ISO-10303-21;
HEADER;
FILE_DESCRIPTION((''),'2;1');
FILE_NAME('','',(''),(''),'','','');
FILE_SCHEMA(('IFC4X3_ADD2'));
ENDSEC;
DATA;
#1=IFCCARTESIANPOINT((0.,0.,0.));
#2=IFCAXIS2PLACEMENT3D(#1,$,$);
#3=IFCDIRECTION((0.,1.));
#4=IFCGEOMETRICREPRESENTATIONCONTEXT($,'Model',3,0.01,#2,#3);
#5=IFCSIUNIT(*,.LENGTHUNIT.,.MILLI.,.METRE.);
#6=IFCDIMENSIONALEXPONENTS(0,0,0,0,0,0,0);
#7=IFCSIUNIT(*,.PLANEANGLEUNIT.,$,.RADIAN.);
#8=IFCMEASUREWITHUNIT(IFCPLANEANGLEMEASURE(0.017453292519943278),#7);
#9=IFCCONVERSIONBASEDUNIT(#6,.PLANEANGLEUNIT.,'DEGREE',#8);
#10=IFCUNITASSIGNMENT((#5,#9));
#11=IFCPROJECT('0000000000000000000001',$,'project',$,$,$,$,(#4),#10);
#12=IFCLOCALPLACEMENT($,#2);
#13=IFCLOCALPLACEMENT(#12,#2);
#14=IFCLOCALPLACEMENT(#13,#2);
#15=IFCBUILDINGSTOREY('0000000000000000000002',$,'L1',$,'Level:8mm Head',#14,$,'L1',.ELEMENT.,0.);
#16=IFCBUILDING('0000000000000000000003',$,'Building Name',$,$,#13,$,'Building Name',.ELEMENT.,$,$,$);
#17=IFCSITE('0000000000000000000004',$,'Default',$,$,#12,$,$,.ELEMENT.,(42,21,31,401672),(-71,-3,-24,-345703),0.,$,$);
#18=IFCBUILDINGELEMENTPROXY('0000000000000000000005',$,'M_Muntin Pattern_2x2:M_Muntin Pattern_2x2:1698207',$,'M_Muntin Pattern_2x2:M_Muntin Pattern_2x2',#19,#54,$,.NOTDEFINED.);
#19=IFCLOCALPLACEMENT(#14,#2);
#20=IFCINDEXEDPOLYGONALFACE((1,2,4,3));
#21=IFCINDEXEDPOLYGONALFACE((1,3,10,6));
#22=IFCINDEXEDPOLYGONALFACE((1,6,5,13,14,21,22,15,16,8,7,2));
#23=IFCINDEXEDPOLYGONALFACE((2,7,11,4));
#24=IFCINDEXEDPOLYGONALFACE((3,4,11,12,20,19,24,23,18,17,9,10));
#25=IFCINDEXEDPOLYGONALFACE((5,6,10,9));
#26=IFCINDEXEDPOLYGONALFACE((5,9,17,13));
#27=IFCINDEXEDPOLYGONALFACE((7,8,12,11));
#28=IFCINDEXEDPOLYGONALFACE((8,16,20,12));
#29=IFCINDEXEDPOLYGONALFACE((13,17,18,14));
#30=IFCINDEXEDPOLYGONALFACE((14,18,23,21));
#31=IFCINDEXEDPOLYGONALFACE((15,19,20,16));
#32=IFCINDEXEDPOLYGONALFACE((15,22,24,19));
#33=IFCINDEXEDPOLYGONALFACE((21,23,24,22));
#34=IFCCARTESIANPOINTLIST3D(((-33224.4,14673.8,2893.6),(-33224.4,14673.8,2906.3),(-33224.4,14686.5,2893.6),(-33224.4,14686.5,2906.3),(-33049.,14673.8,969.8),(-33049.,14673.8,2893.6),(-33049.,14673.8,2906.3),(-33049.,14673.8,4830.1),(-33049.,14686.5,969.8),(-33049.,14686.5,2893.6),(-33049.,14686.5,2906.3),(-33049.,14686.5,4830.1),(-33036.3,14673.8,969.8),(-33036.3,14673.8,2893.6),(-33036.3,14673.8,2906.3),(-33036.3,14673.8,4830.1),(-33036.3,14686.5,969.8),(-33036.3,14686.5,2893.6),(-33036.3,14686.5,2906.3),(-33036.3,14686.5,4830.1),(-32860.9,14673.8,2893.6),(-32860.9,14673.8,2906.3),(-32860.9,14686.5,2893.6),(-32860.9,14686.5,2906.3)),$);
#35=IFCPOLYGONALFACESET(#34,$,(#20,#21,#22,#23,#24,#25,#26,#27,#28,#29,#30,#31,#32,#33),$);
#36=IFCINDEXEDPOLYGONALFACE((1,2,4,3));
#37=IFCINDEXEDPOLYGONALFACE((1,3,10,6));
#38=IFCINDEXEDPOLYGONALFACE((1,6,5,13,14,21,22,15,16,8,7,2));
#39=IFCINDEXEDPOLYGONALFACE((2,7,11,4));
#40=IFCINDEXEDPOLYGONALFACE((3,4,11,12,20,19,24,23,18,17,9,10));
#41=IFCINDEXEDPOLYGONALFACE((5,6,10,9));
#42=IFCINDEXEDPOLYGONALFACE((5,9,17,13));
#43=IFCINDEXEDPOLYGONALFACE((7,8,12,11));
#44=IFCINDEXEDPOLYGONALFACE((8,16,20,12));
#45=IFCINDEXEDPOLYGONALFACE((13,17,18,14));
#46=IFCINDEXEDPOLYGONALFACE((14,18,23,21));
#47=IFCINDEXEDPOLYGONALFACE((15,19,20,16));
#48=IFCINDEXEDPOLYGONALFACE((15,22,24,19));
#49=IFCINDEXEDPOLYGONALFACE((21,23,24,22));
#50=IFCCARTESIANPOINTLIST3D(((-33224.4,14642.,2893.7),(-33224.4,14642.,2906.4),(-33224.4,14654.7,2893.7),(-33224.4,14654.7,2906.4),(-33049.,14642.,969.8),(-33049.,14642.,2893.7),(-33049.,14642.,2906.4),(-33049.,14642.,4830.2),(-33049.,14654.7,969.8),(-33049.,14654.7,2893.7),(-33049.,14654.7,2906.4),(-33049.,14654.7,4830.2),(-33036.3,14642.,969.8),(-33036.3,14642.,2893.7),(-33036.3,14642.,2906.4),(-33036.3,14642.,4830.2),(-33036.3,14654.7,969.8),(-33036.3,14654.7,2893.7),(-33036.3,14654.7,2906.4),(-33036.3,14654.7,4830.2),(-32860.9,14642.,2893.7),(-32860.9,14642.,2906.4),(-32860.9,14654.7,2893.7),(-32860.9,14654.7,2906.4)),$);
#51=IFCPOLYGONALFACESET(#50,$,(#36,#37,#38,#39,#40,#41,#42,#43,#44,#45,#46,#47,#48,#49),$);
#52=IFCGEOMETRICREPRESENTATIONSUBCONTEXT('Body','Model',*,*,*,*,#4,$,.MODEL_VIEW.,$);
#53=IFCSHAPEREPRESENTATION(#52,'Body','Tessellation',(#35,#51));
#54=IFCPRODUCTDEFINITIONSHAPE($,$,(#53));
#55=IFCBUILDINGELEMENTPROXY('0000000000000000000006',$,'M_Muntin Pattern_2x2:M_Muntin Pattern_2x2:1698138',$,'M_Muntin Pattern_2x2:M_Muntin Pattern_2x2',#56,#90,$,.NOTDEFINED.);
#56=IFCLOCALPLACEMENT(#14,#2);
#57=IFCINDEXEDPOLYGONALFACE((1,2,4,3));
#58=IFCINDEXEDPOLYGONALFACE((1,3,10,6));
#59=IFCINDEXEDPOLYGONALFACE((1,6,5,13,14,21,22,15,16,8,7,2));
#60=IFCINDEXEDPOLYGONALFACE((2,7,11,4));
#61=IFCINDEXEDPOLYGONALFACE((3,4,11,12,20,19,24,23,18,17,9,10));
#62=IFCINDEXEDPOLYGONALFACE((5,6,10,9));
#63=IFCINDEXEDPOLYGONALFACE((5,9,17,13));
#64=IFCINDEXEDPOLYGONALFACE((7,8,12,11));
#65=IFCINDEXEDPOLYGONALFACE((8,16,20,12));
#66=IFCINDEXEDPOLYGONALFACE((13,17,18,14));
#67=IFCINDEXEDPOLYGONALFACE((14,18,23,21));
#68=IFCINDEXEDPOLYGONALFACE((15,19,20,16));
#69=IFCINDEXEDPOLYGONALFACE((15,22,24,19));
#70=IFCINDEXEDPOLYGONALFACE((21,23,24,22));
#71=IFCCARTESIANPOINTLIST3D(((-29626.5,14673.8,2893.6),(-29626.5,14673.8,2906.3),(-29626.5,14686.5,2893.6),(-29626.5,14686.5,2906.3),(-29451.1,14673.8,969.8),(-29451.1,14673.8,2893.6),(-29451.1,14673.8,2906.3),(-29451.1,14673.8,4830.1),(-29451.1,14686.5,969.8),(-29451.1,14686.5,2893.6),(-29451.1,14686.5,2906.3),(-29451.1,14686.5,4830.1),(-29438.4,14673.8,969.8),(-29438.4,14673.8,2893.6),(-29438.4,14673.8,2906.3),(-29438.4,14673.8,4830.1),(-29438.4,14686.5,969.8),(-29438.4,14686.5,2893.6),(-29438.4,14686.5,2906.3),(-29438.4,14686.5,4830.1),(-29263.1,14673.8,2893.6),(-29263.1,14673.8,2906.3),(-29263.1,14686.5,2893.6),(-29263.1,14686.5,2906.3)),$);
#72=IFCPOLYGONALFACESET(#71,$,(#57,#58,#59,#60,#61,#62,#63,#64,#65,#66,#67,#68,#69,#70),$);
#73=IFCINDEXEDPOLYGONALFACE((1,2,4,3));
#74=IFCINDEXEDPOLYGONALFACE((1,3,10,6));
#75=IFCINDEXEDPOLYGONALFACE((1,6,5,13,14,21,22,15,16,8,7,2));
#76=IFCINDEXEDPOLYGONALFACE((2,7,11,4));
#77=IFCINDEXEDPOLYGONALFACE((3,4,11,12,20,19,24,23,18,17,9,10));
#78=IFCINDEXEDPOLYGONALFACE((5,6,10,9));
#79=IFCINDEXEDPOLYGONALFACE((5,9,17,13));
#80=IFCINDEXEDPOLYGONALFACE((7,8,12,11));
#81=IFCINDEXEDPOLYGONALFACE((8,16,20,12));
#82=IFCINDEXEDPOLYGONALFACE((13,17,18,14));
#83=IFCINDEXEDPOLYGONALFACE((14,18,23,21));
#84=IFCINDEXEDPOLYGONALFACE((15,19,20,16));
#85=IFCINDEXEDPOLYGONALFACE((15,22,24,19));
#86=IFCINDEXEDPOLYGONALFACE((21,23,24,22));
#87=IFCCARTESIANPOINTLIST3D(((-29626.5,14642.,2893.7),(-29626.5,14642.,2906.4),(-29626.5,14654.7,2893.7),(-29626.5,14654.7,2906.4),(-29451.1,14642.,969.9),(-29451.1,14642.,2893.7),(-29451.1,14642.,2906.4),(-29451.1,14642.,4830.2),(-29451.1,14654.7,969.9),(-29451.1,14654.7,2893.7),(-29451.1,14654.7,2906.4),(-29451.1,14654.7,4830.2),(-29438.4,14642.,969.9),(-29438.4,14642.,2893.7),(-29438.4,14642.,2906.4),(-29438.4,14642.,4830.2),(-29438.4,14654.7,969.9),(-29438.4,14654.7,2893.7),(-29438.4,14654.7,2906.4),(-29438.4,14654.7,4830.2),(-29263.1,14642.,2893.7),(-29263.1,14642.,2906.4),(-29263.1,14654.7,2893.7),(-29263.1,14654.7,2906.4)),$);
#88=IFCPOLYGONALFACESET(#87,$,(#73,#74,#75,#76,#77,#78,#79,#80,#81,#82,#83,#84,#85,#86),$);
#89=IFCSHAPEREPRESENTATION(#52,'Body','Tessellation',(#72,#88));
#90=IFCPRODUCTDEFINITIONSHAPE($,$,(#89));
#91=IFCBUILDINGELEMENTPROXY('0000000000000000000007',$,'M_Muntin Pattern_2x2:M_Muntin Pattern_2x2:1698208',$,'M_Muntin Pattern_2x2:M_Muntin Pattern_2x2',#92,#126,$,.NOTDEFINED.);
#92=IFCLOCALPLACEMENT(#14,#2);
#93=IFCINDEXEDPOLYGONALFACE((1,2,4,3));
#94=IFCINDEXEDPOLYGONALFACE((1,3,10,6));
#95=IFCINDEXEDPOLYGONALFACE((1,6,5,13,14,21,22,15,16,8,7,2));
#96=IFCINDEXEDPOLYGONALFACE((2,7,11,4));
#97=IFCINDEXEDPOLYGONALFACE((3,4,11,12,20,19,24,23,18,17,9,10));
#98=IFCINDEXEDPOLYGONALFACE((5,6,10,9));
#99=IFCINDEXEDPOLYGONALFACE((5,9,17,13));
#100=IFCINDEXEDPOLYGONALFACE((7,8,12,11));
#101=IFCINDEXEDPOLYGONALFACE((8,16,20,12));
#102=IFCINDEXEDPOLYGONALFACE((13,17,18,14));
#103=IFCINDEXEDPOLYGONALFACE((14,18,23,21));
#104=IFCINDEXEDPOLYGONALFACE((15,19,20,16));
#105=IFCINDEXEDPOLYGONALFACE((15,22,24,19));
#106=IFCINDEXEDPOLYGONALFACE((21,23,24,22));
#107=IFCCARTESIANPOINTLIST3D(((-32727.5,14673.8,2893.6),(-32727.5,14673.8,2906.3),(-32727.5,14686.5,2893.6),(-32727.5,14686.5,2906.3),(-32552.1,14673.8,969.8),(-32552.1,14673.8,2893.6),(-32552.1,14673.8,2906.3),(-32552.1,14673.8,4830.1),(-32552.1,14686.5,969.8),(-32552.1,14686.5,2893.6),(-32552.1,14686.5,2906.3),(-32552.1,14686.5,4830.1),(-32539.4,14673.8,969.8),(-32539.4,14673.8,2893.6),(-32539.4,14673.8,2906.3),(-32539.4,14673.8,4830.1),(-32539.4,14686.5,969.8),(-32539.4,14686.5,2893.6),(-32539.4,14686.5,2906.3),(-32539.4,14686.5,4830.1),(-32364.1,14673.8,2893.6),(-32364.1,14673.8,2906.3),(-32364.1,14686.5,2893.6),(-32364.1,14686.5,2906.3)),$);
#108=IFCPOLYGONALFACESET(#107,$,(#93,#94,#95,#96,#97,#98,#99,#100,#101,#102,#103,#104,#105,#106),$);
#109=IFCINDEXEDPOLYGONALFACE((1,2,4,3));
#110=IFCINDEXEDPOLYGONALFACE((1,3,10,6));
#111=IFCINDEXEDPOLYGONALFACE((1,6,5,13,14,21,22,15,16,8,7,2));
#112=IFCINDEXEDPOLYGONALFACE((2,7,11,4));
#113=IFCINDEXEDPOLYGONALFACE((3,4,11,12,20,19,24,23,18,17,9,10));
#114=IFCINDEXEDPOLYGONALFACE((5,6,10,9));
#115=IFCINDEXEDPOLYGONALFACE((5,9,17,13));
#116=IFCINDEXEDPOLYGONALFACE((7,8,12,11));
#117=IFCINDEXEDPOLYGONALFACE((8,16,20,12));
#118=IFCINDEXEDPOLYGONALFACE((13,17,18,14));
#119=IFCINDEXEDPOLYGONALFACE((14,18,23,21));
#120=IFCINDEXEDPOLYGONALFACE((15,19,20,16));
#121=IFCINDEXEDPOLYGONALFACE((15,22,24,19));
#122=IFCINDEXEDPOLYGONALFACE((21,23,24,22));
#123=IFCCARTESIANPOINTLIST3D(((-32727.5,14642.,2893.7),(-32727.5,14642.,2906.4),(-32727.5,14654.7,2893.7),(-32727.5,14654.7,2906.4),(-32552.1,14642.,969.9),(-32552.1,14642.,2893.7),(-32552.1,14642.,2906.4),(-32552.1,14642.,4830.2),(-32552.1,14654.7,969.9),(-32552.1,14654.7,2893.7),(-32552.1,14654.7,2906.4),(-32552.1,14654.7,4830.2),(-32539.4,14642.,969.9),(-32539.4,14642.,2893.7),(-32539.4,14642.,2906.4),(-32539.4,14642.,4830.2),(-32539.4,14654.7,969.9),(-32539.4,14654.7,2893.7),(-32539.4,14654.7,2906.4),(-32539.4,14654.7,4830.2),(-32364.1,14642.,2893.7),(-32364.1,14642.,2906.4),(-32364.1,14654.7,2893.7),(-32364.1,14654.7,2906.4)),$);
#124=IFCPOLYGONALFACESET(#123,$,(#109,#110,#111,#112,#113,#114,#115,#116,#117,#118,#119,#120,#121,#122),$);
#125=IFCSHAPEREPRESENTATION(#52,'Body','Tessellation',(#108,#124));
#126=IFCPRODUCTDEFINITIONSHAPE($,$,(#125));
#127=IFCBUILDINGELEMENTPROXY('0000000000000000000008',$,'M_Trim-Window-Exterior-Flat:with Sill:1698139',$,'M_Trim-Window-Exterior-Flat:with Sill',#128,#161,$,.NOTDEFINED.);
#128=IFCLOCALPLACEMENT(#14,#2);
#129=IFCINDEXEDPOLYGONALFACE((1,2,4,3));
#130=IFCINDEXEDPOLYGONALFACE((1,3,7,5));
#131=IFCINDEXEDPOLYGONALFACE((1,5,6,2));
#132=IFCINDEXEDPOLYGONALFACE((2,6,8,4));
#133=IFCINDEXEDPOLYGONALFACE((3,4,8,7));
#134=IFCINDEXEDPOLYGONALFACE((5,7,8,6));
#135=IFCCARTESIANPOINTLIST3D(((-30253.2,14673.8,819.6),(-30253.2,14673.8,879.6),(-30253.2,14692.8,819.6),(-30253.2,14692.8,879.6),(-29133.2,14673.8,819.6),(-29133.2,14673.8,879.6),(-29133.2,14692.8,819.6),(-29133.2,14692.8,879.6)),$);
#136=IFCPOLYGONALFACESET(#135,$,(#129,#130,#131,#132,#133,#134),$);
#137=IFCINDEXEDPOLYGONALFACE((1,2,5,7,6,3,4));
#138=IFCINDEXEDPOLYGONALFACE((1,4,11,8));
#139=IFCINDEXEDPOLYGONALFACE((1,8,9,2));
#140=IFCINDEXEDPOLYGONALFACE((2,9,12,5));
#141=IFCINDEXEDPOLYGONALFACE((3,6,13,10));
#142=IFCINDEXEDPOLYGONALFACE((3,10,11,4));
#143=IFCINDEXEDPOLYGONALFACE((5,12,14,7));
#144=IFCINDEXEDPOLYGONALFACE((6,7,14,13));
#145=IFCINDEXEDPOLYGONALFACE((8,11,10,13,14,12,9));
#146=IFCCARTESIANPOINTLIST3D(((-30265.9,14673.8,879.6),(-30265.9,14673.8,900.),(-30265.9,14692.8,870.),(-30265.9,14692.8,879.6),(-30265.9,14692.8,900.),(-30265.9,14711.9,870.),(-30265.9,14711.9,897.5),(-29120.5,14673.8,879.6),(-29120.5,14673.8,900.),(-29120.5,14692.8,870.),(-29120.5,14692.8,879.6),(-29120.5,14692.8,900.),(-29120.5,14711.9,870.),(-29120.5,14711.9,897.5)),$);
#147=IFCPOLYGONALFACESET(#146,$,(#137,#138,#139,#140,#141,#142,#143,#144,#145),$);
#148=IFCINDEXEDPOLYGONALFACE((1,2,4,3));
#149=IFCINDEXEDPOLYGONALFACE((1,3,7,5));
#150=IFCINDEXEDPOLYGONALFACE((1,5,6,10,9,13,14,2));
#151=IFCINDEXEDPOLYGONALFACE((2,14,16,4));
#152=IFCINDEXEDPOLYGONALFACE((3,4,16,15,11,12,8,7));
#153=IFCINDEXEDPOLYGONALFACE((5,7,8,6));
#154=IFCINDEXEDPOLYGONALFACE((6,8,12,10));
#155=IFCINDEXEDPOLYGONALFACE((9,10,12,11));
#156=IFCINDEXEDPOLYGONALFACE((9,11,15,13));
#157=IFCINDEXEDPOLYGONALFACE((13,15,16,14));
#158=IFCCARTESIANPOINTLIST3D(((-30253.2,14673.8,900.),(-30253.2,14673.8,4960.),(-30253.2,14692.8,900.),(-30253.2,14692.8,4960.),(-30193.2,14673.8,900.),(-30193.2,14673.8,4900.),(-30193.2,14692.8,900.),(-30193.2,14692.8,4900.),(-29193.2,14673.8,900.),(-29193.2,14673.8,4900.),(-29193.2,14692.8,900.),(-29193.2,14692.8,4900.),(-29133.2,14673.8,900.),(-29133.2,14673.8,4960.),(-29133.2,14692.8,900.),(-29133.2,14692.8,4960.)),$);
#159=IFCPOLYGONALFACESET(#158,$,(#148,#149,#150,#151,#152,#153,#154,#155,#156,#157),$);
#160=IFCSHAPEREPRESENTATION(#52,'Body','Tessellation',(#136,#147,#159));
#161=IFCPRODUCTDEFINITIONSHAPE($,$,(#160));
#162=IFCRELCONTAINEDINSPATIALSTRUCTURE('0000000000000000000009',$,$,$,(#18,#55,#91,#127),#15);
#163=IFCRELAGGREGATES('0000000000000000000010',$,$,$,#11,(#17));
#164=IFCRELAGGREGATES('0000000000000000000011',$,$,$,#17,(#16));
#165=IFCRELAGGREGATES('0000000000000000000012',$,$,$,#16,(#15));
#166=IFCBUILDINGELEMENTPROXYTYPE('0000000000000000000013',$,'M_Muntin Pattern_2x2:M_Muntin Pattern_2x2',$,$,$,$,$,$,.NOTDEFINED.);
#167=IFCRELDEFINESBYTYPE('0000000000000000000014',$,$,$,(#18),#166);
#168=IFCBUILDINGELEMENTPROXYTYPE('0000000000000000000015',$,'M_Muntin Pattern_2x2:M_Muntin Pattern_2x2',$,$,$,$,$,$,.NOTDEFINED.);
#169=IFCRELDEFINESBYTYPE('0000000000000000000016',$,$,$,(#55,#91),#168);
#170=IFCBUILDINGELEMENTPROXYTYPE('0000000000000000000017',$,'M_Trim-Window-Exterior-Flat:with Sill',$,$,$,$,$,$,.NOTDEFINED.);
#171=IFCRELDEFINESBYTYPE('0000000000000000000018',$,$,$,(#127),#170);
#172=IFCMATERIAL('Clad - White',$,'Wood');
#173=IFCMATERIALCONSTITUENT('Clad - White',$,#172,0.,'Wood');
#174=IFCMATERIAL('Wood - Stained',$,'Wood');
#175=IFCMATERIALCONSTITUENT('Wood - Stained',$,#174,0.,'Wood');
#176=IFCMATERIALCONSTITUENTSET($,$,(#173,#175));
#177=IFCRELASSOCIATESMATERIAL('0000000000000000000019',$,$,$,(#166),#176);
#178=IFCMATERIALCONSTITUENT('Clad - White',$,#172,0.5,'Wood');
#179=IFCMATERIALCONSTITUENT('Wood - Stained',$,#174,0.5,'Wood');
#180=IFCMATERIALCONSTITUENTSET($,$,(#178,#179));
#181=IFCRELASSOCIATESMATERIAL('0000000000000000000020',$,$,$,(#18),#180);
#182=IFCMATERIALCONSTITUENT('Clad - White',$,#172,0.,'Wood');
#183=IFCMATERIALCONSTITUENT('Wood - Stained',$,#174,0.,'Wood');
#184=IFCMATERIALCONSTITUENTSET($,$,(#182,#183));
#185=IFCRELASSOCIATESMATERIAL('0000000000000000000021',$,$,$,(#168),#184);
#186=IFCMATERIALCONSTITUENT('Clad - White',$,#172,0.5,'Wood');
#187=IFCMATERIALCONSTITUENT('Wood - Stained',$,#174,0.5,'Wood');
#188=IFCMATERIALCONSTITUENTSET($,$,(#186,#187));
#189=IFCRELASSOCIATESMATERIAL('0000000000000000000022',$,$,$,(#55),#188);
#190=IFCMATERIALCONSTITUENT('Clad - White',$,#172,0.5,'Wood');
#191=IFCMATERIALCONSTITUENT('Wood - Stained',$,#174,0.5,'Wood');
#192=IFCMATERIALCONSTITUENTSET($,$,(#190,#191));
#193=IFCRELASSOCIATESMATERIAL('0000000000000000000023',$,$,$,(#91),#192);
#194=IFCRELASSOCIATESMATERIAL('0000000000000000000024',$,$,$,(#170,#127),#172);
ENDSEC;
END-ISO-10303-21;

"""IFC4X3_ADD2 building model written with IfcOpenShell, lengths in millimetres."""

from ifc_helpers import new_model, entity, si_unit, converted_unit, direction, frame, frame_2d, origin, place, context, subcontext, project, spatial, polyline, rectangle, outline, extrude, source, transform, mapped, material, constituent, constituent_set, type_object, type_shapes, element, save


model = new_model("IFC4X3_ADD2")

# Units and contexts
model_context = context("Model", 3, precision=0.01, world=origin(), true_north=direction((0.0, 1.0)))
body_context = subcontext(model_context, "Body", "Model", "MODEL_VIEW")
ifc_project = project(units=[si_unit("LENGTHUNIT", "METRE", prefix="MILLI"), converted_unit("PLANEANGLEUNIT", "DEGREE", entity("IfcPlaneAngleMeasure", 0.017453292519943278), si_unit("PLANEANGLEUNIT", "RADIAN"), dimensions=[0, 0, 0, 0, 0, 0, 0])], contexts=[model_context])

# Site, building, storey
site_placement = place(None, origin())
site = spatial("IfcSite", under=ifc_project, at=site_placement, Name="Default", CompositionType="ELEMENT", RefLatitude=(42, 21, 31, 401672), RefLongitude=(-71, -3, -24, -345703), RefElevation=0.0)
building_placement = place(site_placement, origin())
building = spatial("IfcBuilding", under=site, at=building_placement, Name="Building Name", LongName="Building Name", CompositionType="ELEMENT")
storey_placement = place(building_placement, origin())
storey = spatial("IfcBuildingStorey", under=building, at=storey_placement, Name="L1", ObjectType="Level:8mm Head", LongName="L1", CompositionType="ELEMENT", Elevation=0.0)

# Building element proxies
ifc_material_1 = material(Name="Clad - White", Category="Wood")
ifc_material_2 = material(Name="Wood - Stained", Category="Wood")
ifc_constituent_1 = constituent(ifc_material_1, Name="Clad - White", Category="Wood", fraction=0.0)
ifc_constituent_2 = constituent(ifc_material_2, Name="Wood - Stained", Category="Wood", fraction=0.0)
ifc_constituent_set_1 = constituent_set(constituents=[ifc_constituent_1, ifc_constituent_2])
building_element_proxy_type_1 = type_object("IfcBuildingElementProxyType", Name="M_Muntin Pattern_2x2:M_Muntin Pattern_2x2", PredefinedType="NOTDEFINED", material=ifc_constituent_set_1)
shared_shape_1 = source(origin(), body_context, "Body", "SweptSolid", [
    extrude(outline(polyline([(6.4, -6.4), (1930.1, -6.4), (1930.1, 6.3), (6.4, 6.3), (6.4, 181.7), (-6.3, 181.7), (-6.3, 6.3), (-1930.2, 6.3), (-1930.2, -6.4), (-6.3, -6.4), (-6.3, -181.7), (6.4, -181.7), (6.4, -6.4)])), frame((0.0, 9.5, 1930.1), z_axis=(0.0, 1.0, 0.0), x_axis=(0.0, 0.0, 1.0)), (0.0, 0.0, 1.0), 12.7),
    extrude(outline(polyline([(6.4, -6.4), (1930.2, -6.4), (1930.2, 6.3), (6.4, 6.3), (6.4, 181.7), (-6.3, 181.7), (-6.3, 6.3), (-1930.2, 6.3), (-1930.2, -6.4), (-6.3, -6.4), (-6.3, -181.7), (6.4, -181.7), (6.4, -6.4)])), frame((0.0, -22.2, 1930.2), z_axis=(0.0, 1.0, 0.0), x_axis=(0.0, 0.0, 1.0)), (0.0, 0.0, 1.0), 12.7),
])
type_shapes(building_element_proxy_type_1, [shared_shape_1])
ifc_constituent_3 = constituent(ifc_material_1, Name="Clad - White", Category="Wood", fraction=0.5)
ifc_constituent_4 = constituent(ifc_material_2, Name="Wood - Stained", Category="Wood", fraction=0.5)
ifc_constituent_set_2 = constituent_set(constituents=[ifc_constituent_3, ifc_constituent_4])
proxy_1_placement = place(storey_placement, frame((-33042.6, 14664.3, 969.8)))
element("IfcBuildingElementProxy", 1, at=proxy_1_placement, inside=storey, type_object=building_element_proxy_type_1, material=ifc_constituent_set_2, Name="M_Muntin Pattern_2x2:M_Muntin Pattern_2x2:1698207", ObjectType="M_Muntin Pattern_2x2:M_Muntin Pattern_2x2", PredefinedType="NOTDEFINED", context=body_context, shape_type="MappedRepresentation", body=[
    mapped(shared_shape_1, transform((0.0, 0.0, 0.0), scale=1.0)),
])
ifc_constituent_5 = constituent(ifc_material_1, Name="Clad - White", Category="Wood", fraction=0.5)
ifc_constituent_6 = constituent(ifc_material_2, Name="Wood - Stained", Category="Wood", fraction=0.5)
ifc_constituent_set_3 = constituent_set(constituents=[ifc_constituent_5, ifc_constituent_6])
ifc_constituent_7 = constituent(ifc_material_1, Name="Clad - White", Category="Wood", fraction=0.0)
ifc_constituent_8 = constituent(ifc_material_2, Name="Wood - Stained", Category="Wood", fraction=0.0)
ifc_constituent_set_4 = constituent_set(constituents=[ifc_constituent_7, ifc_constituent_8])
building_element_proxy_type_2 = type_object("IfcBuildingElementProxyType", Name="M_Muntin Pattern_2x2:M_Muntin Pattern_2x2", PredefinedType="NOTDEFINED", material=ifc_constituent_set_4)
shared_shape_2 = source(origin(), body_context, "Body", "SweptSolid", [
    extrude(outline(polyline([(6.4, -6.4), (1930.1, -6.4), (1930.1, 6.3), (6.4, 6.3), (6.4, 181.7), (-6.3, 181.7), (-6.3, 6.3), (-1930.2, 6.3), (-1930.2, -6.4), (-6.3, -6.4), (-6.3, -181.7), (6.4, -181.7), (6.4, -6.4)])), frame((0.0, -22.2, 1930.1), z_axis=(0.0, 1.0, 0.0), x_axis=(0.0, 0.0, 1.0)), (0.0, 0.0, 1.0), 12.7),
    extrude(outline(polyline([(6.4, -6.4), (1930.2, -6.4), (1930.2, 6.3), (6.4, 6.3), (6.4, 181.7), (-6.3, 181.7), (-6.3, 6.3), (-1930.2, 6.3), (-1930.2, -6.4), (-6.3, -6.4), (-6.3, -181.7), (6.4, -181.7), (6.4, -6.4)])), frame((0.0, 9.5, 1930.2), z_axis=(0.0, 1.0, 0.0), x_axis=(0.0, 0.0, 1.0)), (0.0, 0.0, 1.0), 12.7),
])
type_shapes(building_element_proxy_type_2, [shared_shape_2])
proxy_2_placement = place(storey_placement, frame((-29444.8, 14664.3, 969.9), z_axis=(0.0, 0.0, 1.0), x_axis=(-1.0, 0.0, 0.0)))
element("IfcBuildingElementProxy", 2, at=proxy_2_placement, inside=storey, type_object=building_element_proxy_type_2, material=ifc_constituent_set_3, Name="M_Muntin Pattern_2x2:M_Muntin Pattern_2x2:1698138", ObjectType="M_Muntin Pattern_2x2:M_Muntin Pattern_2x2", PredefinedType="NOTDEFINED", context=body_context, shape_type="MappedRepresentation", body=[
    mapped(shared_shape_2, transform((0.0, 0.0, 0.0), scale=1.0)),
])
ifc_constituent_9 = constituent(ifc_material_1, Name="Clad - White", Category="Wood", fraction=0.5)
ifc_constituent_10 = constituent(ifc_material_2, Name="Wood - Stained", Category="Wood", fraction=0.5)
ifc_constituent_set_5 = constituent_set(constituents=[ifc_constituent_9, ifc_constituent_10])
proxy_3_placement = place(storey_placement, frame((-32545.8, 14664.3, 969.9), z_axis=(0.0, 0.0, 1.0), x_axis=(-1.0, 0.0, 0.0)))
element("IfcBuildingElementProxy", 3, at=proxy_3_placement, inside=storey, type_object=building_element_proxy_type_2, material=ifc_constituent_set_5, Name="M_Muntin Pattern_2x2:M_Muntin Pattern_2x2:1698208", ObjectType="M_Muntin Pattern_2x2:M_Muntin Pattern_2x2", PredefinedType="NOTDEFINED", context=body_context, shape_type="MappedRepresentation", body=[
    mapped(shared_shape_2, transform((0.0, 0.0, 0.0), scale=1.0)),
])
building_element_proxy_type_3 = type_object("IfcBuildingElementProxyType", Name="M_Trim-Window-Exterior-Flat:with Sill", PredefinedType="NOTDEFINED", material=ifc_material_1)
shared_shape_3 = source(origin(), body_context, "Body", "SweptSolid", [
    extrude(rectangle(XDim=1120.0, YDim=60.0, at=frame_2d((0.0, 0.0), x_axis=(1.0, 0.0))), frame((0.0, -4050.4, 0.0), z_axis=(0.0, 0.0, 1.0), x_axis=(-1.0, 0.0, 0.0)), (0.0, 0.0, 1.0), 19.0),
    extrude(outline(polyline([(-19.0, -15.2), (0.0, -15.2), (0.0, -5.7), (19.0, -5.7), (19.0, 14.8), (0.0, 14.8), (-19.0, 12.3), (-19.0, -15.2)])), frame((-572.7, -4014.8, 19.0), z_axis=(1.0, 0.0, 0.0), x_axis=(0.0, 0.0, -1.0)), (0.0, 0.0, 1.0), 1145.4),
    extrude(outline(polyline([(-2045.0, -560.0), (2015.0, -560.0), (2015.0, -500.0), (-1985.0, -500.0), (-1985.0, 500.0), (2015.0, 500.0), (2015.0, 560.0), (-2045.0, 560.0), (-2045.0, -560.0)])), frame((0.0, -1985.0, 0.0), z_axis=(0.0, 0.0, 1.0), x_axis=(0.0, -1.0, 0.0)), (0.0, 0.0, 1.0), 19.0),
])
type_shapes(building_element_proxy_type_3, [shared_shape_3])
for number, where, z_axis, x_axis, name in (
    (4, (-29693.2, 14673.8, 4900.0), (0.0, 1.0, 0.0), (-1.0, 0.0, 0.0), "M_Trim-Window-Exterior-Flat:with Sill:1698139"),
):
    element("IfcBuildingElementProxy", number, at=place(storey_placement, frame(where, z_axis=z_axis, x_axis=x_axis)), inside=storey, type_object=building_element_proxy_type_3, material=ifc_material_1, Name=name, ObjectType="M_Trim-Window-Exterior-Flat:with Sill", PredefinedType="NOTDEFINED", context=body_context, shape_type="MappedRepresentation", body=[
        mapped(shared_shape_3, transform((0.0, 0.0, 0.0), scale=1.0)),
    ])

save(model, "model.ifc")
